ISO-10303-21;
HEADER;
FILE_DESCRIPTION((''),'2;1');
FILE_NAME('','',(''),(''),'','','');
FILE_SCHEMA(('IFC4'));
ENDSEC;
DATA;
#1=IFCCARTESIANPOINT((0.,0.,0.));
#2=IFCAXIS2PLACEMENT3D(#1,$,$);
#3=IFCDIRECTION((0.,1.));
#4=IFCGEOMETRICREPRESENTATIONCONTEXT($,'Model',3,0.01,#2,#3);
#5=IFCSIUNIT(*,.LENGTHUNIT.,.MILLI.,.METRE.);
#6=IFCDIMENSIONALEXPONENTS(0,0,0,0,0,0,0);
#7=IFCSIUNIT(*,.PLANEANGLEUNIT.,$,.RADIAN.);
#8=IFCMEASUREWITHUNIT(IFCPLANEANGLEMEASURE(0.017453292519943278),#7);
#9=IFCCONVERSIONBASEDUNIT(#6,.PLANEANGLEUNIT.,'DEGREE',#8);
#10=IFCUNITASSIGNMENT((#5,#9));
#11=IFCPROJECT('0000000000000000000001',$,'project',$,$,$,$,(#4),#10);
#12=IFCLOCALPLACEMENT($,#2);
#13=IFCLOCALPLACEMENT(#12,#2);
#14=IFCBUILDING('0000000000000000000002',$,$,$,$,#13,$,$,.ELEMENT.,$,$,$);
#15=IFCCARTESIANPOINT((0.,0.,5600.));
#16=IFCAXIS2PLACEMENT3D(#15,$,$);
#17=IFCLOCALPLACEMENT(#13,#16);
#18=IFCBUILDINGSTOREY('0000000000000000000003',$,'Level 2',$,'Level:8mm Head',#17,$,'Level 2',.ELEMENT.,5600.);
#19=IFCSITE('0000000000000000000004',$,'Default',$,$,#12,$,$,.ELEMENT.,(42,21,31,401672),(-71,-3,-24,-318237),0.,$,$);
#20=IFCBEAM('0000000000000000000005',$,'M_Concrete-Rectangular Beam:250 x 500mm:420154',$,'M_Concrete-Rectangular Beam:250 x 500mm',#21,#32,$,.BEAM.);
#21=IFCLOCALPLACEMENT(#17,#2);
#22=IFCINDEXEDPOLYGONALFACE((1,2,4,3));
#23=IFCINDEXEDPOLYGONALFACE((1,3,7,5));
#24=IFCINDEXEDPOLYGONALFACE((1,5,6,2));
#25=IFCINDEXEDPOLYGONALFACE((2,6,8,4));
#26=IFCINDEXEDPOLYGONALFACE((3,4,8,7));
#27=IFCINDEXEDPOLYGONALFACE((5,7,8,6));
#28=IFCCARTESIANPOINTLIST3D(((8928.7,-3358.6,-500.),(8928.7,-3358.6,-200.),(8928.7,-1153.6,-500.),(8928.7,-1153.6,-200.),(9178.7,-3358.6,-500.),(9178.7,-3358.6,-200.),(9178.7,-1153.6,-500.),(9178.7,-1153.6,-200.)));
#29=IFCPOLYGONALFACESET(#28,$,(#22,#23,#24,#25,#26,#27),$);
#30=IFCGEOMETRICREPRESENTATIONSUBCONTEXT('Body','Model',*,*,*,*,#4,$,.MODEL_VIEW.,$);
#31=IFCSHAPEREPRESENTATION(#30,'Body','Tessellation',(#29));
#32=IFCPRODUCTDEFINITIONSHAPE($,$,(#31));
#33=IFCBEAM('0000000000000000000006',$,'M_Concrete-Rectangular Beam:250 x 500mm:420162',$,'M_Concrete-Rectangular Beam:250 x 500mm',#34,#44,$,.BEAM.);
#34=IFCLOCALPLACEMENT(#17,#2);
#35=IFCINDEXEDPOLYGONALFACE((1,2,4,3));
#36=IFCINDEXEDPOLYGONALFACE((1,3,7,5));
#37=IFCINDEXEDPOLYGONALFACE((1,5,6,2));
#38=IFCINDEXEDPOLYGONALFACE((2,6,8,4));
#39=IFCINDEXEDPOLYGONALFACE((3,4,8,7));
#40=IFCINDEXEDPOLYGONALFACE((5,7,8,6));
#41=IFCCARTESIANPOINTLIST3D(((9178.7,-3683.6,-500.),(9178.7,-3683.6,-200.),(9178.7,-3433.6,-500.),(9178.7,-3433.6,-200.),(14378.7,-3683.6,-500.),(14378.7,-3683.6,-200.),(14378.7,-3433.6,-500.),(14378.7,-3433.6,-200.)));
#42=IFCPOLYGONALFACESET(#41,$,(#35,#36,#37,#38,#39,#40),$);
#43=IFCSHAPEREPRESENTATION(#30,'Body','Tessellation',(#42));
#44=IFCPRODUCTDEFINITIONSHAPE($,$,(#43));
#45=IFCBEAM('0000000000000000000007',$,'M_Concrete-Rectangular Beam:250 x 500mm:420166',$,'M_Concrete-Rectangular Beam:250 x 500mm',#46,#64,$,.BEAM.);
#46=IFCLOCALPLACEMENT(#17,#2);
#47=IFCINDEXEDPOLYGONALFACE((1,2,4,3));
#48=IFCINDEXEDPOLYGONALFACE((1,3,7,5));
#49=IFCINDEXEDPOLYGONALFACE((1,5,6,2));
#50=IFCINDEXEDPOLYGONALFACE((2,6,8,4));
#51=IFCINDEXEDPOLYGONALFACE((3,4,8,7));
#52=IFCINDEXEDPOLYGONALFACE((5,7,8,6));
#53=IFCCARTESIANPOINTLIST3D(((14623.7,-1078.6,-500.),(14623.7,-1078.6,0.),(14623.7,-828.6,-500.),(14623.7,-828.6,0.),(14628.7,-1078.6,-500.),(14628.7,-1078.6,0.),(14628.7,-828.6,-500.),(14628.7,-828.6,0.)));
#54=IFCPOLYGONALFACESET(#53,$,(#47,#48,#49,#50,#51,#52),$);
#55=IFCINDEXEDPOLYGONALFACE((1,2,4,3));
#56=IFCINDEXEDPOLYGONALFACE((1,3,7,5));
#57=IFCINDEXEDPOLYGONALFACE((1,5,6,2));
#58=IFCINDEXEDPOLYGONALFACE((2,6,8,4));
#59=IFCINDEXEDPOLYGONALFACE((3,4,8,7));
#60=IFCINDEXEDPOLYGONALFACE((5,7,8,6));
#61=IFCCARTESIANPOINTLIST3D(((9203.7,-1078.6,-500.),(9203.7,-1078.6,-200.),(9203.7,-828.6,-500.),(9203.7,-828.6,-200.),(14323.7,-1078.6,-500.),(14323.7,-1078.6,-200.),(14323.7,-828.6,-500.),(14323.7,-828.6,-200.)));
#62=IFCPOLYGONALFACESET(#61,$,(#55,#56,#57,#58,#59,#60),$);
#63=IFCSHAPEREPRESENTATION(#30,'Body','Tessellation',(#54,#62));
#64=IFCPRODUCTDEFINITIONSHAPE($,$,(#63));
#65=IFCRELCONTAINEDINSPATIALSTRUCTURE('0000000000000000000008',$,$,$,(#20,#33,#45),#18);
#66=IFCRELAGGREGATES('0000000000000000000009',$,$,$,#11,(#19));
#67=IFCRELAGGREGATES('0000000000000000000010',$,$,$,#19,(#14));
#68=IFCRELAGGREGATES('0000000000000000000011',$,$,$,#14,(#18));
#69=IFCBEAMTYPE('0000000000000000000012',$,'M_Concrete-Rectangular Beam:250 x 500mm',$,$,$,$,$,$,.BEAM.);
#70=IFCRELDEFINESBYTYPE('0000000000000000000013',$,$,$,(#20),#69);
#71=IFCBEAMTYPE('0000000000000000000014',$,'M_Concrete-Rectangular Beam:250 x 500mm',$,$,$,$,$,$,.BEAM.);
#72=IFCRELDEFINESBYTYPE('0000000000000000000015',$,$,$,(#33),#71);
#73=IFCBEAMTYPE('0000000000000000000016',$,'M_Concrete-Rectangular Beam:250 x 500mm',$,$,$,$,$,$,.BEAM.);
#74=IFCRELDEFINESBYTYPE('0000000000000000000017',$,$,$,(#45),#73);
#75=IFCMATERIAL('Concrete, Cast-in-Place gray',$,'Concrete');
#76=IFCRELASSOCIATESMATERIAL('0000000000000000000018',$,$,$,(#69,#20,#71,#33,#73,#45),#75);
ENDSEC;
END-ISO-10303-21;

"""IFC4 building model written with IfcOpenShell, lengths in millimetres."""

from ifc_helpers import new_model, entity, si_unit, converted_unit, direction, frame, origin, place, context, subcontext, project, spatial, indexed_curve, outline, extrude, source, transform, mapped, material, type_object, type_shapes, element, save


model = new_model("IFC4")

# Units and contexts
model_context = context("Model", 3, precision=0.01, world=origin(), true_north=direction((0.0, 1.0)))
body_context = subcontext(model_context, "Body", "Model", "MODEL_VIEW")
ifc_project = project(units=[si_unit("LENGTHUNIT", "METRE", prefix="MILLI"), converted_unit("PLANEANGLEUNIT", "DEGREE", entity("IfcPlaneAngleMeasure", 0.017453292519943278), si_unit("PLANEANGLEUNIT", "RADIAN"), dimensions=[0, 0, 0, 0, 0, 0, 0])], contexts=[model_context])

# Site, building, storey
site_placement = place(None, origin())
site = spatial("IfcSite", under=ifc_project, at=site_placement, Name="Default", CompositionType="ELEMENT", RefLatitude=(42, 21, 31, 401672), RefLongitude=(-71, -3, -24, -318237), RefElevation=0.0)
building_placement = place(site_placement, origin())
building = spatial("IfcBuilding", under=site, at=building_placement, CompositionType="ELEMENT")
storey_placement = place(building_placement, frame((0.0, 0.0, 5600.0)))
storey = spatial("IfcBuildingStorey", under=building, at=storey_placement, Name="Level 2", ObjectType="Level:8mm Head", LongName="Level 2", CompositionType="ELEMENT", Elevation=5600.0)

# Beams
ifc_material_1 = material(Name="Concrete, Cast-in-Place gray", Category="Concrete")
beam_type_1 = type_object("IfcBeamType", Name="M_Concrete-Rectangular Beam:250 x 500mm", PredefinedType="BEAM", material=ifc_material_1)
shared_shape_1 = source(origin(), body_context, "Body", "SweptSolid", [
    extrude(outline(indexed_curve([(-125.0, -150.0), (125.0, -150.0), (125.0, 150.0), (-125.0, 150.0), (-125.0, -150.0)], self_intersect=False)), frame((9053.7, -1153.6, 5250.0), z_axis=(0.0, -1.0, 0.0), x_axis=(-1.0, 0.0, 0.0)), (0.0, 0.0, 1.0), 2205.0),
])
type_shapes(beam_type_1, [shared_shape_1])
beam_1_placement = place(storey_placement, frame((0.0, 0.0, -5600.0)))
element("IfcBeam", 1, at=beam_1_placement, inside=storey, type_object=beam_type_1, material=ifc_material_1, Name="M_Concrete-Rectangular Beam:250 x 500mm:420154", ObjectType="M_Concrete-Rectangular Beam:250 x 500mm", PredefinedType="BEAM", context=body_context, shape_type="MappedRepresentation", body=[
    mapped(shared_shape_1, transform((0.0, 0.0, 0.0), scale=1.0)),
])
beam_type_2 = type_object("IfcBeamType", Name="M_Concrete-Rectangular Beam:250 x 500mm", PredefinedType="BEAM", material=ifc_material_1)
shared_shape_2 = source(origin(), body_context, "Body", "SweptSolid", [
    extrude(outline(indexed_curve([(-150.0, -125.0), (150.0, -125.0), (150.0, 125.0), (-150.0, 125.0), (-150.0, -125.0)], self_intersect=False)), frame((9178.7, -3558.6, 5250.0), z_axis=(1.0, 0.0, 0.0), x_axis=(0.0, 0.0, -1.0)), (0.0, 0.0, 1.0), 5200.0),
])
type_shapes(beam_type_2, [shared_shape_2])
beam_2_placement = place(storey_placement, frame((0.0, 0.0, -5600.0)))
element("IfcBeam", 2, at=beam_2_placement, inside=storey, type_object=beam_type_2, material=ifc_material_1, Name="M_Concrete-Rectangular Beam:250 x 500mm:420162", ObjectType="M_Concrete-Rectangular Beam:250 x 500mm", PredefinedType="BEAM", context=body_context, shape_type="MappedRepresentation", body=[
    mapped(shared_shape_2, transform((0.0, 0.0, 0.0), scale=1.0)),
])
beam_type_3 = type_object("IfcBeamType", Name="M_Concrete-Rectangular Beam:250 x 500mm", PredefinedType="BEAM", material=ifc_material_1)
shared_shape_3 = source(origin(), body_context, "Body", "SweptSolid", [
    extrude(outline(indexed_curve([(-250.0, -125.0), (250.0, -125.0), (250.0, 125.0), (-250.0, 125.0), (-250.0, -125.0)], self_intersect=False)), frame((14623.7, -953.6, 5350.0), z_axis=(1.0, 0.0, 0.0), x_axis=(0.0, 0.0, -1.0)), (0.0, 0.0, 1.0), 5.0),
    extrude(outline(indexed_curve([(-150.0, -125.0), (150.0, -125.0), (150.0, 125.0), (-150.0, 125.0), (-150.0, -125.0)], self_intersect=False)), frame((9203.7, -953.6, 5250.0), z_axis=(1.0, 0.0, 0.0), x_axis=(0.0, 0.0, -1.0)), (0.0, 0.0, 1.0), 5120.0),
])
type_shapes(beam_type_3, [shared_shape_3])
beam_3_placement = place(storey_placement, frame((0.0, 0.0, -5600.0)))
element("IfcBeam", 3, at=beam_3_placement, inside=storey, type_object=beam_type_3, material=ifc_material_1, Name="M_Concrete-Rectangular Beam:250 x 500mm:420166", ObjectType="M_Concrete-Rectangular Beam:250 x 500mm", PredefinedType="BEAM", context=body_context, shape_type="MappedRepresentation", body=[
    mapped(shared_shape_3, transform((0.0, 0.0, 0.0), scale=1.0)),
])

save(model, "model.ifc")
